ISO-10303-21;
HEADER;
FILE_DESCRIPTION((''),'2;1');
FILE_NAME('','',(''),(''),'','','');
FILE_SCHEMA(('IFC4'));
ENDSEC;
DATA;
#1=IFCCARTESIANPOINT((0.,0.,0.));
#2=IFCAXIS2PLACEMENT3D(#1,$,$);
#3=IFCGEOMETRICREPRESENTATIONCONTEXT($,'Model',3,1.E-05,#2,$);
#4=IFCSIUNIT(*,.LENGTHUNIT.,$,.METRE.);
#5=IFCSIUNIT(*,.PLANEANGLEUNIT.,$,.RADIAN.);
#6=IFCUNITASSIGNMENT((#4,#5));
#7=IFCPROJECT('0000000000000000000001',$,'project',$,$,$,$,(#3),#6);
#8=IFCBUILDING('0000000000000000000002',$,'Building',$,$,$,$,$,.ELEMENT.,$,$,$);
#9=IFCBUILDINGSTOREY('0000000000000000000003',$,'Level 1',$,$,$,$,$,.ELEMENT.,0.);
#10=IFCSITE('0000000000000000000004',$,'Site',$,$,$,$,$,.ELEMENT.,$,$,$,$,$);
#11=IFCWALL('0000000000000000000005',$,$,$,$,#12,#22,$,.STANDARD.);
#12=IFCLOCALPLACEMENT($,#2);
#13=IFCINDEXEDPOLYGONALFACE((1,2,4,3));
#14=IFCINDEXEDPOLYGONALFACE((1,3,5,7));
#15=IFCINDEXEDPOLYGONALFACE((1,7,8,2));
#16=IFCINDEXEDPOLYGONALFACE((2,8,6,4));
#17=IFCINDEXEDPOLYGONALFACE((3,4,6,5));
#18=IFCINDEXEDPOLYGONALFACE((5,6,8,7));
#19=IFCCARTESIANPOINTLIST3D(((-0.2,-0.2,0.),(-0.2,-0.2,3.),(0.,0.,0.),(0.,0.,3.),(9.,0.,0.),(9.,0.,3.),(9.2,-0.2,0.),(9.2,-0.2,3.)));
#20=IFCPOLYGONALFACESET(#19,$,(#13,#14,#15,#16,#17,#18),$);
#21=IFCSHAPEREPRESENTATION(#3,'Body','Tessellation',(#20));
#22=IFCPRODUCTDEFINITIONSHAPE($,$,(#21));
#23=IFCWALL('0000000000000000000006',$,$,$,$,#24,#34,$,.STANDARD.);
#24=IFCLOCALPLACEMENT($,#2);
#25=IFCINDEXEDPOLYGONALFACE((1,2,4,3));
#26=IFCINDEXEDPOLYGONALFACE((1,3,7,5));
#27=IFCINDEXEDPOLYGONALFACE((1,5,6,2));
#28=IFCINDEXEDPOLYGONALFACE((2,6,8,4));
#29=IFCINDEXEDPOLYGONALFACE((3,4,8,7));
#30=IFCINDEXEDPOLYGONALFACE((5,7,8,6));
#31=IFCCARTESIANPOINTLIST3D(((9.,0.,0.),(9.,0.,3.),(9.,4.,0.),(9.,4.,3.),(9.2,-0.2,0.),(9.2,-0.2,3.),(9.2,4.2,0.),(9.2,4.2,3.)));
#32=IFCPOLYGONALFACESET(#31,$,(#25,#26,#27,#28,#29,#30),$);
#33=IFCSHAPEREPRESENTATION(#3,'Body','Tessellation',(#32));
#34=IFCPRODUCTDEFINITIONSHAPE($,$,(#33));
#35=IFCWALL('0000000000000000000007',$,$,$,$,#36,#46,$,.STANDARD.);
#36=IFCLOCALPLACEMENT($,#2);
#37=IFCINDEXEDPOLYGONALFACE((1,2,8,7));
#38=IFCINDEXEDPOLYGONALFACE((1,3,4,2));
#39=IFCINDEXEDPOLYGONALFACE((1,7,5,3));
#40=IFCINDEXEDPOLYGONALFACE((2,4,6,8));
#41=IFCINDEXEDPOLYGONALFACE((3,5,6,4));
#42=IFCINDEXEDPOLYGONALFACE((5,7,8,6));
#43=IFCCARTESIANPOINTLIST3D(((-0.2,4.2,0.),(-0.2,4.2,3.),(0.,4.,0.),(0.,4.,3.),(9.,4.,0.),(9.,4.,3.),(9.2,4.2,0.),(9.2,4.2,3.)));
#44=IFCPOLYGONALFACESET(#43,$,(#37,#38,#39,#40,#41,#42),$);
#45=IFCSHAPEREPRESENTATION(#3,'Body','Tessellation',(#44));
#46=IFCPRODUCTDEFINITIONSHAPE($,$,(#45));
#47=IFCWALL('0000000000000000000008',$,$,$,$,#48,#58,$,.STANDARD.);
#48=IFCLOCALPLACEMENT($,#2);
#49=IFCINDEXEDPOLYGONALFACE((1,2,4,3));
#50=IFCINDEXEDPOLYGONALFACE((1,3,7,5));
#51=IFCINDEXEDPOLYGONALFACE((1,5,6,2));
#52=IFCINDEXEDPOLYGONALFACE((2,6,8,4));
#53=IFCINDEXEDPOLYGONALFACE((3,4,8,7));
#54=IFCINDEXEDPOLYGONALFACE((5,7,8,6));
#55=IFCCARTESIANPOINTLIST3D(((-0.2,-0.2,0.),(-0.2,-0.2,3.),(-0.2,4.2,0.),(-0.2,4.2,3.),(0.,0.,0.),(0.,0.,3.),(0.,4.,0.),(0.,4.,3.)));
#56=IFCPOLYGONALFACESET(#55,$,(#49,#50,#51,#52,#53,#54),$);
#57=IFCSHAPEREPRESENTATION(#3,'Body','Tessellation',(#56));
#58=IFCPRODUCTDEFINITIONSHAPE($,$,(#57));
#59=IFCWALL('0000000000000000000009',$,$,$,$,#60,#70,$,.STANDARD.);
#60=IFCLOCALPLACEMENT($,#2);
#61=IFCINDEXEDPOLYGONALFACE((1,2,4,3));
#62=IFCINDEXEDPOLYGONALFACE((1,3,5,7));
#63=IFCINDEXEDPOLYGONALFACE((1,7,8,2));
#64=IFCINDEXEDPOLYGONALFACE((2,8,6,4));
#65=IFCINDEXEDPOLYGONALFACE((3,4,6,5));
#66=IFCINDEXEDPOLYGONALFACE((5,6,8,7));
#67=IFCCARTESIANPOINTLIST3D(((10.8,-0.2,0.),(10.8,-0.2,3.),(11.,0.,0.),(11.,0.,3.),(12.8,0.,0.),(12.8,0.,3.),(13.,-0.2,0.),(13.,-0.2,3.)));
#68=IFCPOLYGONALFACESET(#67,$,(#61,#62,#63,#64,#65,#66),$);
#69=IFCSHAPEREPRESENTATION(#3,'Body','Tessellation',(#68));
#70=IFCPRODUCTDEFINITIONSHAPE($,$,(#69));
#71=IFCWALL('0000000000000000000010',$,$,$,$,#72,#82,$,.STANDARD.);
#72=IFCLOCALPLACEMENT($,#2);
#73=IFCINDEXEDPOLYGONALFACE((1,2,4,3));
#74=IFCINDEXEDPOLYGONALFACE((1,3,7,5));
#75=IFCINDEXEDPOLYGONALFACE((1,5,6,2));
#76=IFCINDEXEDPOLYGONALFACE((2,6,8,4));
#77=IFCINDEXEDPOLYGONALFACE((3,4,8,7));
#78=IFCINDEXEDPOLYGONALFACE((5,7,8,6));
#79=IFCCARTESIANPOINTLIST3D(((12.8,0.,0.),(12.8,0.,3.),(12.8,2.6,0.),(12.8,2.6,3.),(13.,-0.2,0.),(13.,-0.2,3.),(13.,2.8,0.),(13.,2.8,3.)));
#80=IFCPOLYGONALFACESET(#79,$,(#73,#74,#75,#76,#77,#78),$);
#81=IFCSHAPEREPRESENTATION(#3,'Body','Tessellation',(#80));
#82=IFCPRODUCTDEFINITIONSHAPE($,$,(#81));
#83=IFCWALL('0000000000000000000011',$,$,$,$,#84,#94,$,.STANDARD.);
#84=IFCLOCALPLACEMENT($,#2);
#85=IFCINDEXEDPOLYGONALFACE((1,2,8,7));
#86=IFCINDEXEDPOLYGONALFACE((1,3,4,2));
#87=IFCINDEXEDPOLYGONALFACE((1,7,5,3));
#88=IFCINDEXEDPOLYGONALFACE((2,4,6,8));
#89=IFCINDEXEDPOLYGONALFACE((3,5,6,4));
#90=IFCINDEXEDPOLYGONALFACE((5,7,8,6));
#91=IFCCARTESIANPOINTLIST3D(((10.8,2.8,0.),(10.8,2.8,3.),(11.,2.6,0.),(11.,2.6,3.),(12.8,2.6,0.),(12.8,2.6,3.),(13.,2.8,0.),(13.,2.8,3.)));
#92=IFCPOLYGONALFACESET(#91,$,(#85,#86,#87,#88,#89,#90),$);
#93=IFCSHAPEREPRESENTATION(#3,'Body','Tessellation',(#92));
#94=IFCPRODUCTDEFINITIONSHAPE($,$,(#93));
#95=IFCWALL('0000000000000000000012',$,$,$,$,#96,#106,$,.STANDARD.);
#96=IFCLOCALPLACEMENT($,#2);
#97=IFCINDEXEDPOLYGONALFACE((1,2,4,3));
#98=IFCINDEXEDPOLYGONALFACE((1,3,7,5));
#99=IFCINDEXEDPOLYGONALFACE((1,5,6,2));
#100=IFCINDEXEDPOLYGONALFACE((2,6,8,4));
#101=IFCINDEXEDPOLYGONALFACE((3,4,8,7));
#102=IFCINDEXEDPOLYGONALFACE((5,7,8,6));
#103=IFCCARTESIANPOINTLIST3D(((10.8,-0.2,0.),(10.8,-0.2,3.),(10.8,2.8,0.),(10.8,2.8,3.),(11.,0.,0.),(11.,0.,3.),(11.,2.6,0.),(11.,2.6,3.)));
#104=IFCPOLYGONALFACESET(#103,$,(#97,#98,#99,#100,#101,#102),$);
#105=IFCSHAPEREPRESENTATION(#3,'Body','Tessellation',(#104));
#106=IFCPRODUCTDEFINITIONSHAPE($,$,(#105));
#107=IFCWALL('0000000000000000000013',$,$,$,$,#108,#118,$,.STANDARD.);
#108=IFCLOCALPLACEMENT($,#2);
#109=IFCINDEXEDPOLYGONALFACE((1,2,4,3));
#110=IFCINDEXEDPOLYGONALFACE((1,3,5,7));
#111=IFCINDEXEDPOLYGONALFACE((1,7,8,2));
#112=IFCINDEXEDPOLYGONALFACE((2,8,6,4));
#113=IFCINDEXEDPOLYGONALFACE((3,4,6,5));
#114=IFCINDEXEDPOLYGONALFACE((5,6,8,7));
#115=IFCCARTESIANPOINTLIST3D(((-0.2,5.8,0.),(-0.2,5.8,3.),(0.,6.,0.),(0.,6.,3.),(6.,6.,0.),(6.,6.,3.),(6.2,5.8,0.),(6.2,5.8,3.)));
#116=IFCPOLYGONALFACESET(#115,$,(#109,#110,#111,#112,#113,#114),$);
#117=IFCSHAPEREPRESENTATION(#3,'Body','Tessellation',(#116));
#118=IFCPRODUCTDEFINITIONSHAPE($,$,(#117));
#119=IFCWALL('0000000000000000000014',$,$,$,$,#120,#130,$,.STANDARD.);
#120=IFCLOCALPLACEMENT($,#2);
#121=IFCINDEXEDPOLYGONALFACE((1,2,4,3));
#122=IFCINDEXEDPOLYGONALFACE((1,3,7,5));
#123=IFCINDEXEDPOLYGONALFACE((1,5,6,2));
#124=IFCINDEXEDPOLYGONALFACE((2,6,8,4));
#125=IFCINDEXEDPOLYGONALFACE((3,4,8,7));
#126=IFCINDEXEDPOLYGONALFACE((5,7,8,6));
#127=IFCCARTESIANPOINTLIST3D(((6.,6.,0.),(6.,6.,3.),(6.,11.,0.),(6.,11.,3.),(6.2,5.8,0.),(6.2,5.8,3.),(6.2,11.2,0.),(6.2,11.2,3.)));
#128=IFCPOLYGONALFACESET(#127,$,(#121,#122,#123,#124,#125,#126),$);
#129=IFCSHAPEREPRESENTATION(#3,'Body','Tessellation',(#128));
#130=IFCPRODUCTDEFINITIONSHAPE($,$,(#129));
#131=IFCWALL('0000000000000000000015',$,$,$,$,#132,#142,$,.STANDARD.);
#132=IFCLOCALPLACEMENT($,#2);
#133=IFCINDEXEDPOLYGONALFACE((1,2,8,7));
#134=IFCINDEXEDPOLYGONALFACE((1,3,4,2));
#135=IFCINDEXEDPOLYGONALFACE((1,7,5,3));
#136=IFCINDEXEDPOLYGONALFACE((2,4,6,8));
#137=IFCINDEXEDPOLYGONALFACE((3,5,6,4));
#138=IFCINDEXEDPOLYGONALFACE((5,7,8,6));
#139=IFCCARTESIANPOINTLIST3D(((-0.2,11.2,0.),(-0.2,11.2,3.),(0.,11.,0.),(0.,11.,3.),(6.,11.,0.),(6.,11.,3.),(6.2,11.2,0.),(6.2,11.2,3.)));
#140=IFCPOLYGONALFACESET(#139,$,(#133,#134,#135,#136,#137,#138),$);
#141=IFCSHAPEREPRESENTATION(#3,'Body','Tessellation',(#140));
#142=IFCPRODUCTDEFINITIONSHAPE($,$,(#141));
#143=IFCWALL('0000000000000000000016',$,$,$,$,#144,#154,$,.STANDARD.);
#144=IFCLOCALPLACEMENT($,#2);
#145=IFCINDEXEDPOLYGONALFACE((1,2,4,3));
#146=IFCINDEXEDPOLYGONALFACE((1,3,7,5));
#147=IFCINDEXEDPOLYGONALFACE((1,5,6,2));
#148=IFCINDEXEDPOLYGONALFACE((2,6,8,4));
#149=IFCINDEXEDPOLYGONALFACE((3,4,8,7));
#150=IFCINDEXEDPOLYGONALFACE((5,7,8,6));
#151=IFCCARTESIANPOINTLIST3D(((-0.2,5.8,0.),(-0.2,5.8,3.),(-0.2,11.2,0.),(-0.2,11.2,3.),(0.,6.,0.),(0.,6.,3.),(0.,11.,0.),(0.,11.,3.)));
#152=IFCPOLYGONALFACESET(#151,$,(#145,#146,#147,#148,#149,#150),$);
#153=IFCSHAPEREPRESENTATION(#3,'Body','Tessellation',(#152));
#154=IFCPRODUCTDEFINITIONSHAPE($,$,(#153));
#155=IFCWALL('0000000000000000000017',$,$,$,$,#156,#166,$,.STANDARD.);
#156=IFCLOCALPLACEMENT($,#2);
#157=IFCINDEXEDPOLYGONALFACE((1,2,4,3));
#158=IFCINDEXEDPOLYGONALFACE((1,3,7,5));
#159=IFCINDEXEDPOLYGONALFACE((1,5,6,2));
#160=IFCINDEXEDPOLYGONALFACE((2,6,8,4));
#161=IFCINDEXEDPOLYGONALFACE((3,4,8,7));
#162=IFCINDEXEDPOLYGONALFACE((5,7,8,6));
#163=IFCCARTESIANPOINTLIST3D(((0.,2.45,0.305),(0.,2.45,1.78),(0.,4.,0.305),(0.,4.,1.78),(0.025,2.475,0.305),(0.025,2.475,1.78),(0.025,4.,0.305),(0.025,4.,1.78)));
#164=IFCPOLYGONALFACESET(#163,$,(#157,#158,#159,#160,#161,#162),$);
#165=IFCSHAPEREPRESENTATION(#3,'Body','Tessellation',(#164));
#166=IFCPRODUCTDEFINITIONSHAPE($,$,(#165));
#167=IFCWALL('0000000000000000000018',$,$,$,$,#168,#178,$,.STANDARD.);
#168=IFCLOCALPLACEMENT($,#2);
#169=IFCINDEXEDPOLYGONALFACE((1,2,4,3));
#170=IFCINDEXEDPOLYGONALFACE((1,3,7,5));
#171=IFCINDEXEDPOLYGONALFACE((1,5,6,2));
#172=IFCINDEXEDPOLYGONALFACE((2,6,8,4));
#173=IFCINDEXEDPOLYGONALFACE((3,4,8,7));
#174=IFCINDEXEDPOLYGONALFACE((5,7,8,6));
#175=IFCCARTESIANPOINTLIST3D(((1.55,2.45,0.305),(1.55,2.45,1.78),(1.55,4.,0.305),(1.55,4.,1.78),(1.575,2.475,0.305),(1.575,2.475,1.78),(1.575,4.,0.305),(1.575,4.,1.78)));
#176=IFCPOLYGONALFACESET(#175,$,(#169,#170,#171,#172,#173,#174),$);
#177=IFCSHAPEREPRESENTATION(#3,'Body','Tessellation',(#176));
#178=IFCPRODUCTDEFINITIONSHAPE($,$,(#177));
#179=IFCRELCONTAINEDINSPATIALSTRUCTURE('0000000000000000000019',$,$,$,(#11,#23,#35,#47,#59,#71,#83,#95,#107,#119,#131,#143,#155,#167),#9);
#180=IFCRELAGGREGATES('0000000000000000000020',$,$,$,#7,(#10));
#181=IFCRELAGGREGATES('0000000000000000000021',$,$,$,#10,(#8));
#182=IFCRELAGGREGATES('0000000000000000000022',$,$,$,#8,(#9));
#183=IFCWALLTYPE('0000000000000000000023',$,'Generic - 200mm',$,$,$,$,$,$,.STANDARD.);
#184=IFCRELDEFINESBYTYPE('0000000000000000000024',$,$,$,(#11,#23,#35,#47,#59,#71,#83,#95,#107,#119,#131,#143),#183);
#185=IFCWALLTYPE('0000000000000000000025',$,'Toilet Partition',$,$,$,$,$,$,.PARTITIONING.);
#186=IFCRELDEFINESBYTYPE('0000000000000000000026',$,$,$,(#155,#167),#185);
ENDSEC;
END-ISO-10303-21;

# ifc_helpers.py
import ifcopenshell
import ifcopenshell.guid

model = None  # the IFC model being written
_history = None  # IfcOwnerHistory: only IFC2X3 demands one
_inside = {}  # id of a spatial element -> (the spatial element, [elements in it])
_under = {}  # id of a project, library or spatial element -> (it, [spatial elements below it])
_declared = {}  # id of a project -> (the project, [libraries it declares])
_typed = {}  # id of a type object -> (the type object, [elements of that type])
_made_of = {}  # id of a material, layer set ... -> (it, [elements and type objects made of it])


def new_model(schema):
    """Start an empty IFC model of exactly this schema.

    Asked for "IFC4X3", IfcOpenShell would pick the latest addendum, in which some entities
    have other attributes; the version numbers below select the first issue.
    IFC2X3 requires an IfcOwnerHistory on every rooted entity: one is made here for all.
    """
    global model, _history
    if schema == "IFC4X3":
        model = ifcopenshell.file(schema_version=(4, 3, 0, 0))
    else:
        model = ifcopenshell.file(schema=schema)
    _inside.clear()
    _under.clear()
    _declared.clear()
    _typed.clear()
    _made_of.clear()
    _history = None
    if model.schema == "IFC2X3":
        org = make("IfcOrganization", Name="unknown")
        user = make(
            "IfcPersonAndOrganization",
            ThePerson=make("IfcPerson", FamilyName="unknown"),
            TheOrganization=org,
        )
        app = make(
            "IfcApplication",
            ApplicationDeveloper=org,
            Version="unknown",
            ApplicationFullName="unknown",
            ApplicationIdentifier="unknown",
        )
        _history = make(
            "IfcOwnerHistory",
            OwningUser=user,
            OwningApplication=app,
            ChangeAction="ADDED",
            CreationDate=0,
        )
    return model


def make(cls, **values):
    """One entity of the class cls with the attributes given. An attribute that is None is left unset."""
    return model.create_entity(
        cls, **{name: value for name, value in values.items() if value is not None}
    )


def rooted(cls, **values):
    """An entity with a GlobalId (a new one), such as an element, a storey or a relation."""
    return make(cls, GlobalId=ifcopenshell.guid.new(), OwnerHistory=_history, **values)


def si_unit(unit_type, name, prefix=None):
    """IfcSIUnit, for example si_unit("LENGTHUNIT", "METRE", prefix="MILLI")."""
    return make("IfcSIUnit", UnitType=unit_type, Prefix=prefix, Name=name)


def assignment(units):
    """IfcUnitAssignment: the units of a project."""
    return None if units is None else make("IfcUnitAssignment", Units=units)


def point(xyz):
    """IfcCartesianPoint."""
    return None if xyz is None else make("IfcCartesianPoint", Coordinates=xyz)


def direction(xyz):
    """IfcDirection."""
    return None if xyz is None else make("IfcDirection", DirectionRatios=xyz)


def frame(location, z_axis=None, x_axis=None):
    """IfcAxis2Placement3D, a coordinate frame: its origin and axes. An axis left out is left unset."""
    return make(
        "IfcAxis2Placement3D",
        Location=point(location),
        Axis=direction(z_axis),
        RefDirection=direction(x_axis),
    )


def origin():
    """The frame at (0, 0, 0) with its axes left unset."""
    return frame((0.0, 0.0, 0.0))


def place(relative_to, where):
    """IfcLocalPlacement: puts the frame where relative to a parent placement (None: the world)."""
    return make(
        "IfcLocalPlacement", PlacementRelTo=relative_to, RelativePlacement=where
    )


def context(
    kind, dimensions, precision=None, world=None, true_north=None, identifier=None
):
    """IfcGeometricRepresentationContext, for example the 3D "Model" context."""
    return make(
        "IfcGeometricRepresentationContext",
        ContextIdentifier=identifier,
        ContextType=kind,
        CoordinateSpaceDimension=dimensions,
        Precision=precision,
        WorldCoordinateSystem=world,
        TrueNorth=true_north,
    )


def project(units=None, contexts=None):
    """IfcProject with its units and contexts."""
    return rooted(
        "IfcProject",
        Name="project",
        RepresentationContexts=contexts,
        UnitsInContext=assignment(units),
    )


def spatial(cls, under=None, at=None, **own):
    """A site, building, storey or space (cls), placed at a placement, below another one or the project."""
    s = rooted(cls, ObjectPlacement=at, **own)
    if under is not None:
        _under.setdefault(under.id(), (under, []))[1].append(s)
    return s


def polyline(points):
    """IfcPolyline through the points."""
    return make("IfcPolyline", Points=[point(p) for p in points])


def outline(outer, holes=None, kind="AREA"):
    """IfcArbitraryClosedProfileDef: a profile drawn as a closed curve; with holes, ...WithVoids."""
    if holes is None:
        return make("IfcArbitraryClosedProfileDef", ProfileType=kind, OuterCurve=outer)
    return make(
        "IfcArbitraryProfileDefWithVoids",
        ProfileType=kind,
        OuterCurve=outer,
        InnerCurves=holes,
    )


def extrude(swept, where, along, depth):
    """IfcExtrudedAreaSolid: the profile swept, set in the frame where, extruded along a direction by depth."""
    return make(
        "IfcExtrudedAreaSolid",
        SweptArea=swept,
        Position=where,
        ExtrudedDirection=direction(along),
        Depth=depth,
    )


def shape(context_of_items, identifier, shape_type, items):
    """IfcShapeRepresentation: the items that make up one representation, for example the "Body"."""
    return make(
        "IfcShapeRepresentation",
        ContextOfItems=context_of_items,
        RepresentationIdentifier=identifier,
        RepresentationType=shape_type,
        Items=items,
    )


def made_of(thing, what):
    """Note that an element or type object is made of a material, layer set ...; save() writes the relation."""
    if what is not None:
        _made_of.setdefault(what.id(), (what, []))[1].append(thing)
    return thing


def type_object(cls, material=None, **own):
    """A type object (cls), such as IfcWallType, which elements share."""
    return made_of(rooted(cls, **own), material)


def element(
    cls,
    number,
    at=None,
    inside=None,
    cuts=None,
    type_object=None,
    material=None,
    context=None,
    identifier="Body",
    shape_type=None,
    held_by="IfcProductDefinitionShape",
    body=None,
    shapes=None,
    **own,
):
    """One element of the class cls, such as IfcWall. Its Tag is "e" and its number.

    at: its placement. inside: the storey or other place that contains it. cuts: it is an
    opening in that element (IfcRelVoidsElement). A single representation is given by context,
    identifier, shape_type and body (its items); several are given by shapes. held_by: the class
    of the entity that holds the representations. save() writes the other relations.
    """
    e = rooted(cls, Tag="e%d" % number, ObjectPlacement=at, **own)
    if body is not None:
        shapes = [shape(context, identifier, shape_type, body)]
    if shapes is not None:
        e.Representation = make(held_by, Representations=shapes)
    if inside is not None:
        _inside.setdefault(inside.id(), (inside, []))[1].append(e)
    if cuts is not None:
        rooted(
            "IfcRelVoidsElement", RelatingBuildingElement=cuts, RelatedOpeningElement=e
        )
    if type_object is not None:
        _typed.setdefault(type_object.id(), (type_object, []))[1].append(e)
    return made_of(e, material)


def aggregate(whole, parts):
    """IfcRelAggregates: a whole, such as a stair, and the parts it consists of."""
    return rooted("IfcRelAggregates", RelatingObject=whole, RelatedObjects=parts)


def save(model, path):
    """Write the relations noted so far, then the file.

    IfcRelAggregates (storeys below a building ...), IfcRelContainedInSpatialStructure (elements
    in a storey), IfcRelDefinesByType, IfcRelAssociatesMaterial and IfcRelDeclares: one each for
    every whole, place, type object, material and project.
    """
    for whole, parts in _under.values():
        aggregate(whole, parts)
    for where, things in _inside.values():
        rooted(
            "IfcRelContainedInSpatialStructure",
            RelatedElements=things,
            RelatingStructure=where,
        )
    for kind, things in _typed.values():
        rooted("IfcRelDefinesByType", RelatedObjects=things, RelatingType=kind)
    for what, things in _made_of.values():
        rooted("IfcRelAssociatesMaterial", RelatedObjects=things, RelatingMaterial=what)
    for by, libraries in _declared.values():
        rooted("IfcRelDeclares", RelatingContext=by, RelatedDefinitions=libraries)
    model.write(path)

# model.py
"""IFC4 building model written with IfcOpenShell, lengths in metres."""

from ifc_helpers import new_model, si_unit, frame, origin, place, context, project, spatial, polyline, outline, extrude, type_object, element, save


model = new_model("IFC4")

# Units and contexts
model_context = context("Model", 3, precision=1e-05, world=origin())
ifc_project = project(units=[si_unit("LENGTHUNIT", "METRE"), si_unit("PLANEANGLEUNIT", "RADIAN")], contexts=[model_context])

# Site, building, storey
site = spatial("IfcSite", under=ifc_project, Name="Site", CompositionType="ELEMENT")
building = spatial("IfcBuilding", under=site, Name="Building", CompositionType="ELEMENT")
storey = spatial("IfcBuildingStorey", under=building, Name="Level 1", CompositionType="ELEMENT", Elevation=0.0)

# Walls
wall_type_1 = type_object("IfcWallType", Name="Generic - 200mm", PredefinedType="STANDARD")
wall_1_placement = place(None, frame((-0.1, -0.1, 0.0), z_axis=(0.0, 0.0, 1.0), x_axis=(1.0, 0.0, 0.0)))
element("IfcWall", 1, at=wall_1_placement, inside=storey, type_object=wall_type_1, PredefinedType="STANDARD", context=model_context, shape_type="SweptSolid", body=[
    extrude(outline(polyline([(-0.1, -0.1), (9.3, -0.1), (9.1, 0.1), (0.1, 0.1), (-0.1, -0.1)])), origin(), (0.0, 0.0, 1.0), 3.0),
])
wall_2_placement = place(None, frame((9.1, -0.1, 0.0), z_axis=(0.0, 0.0, 1.0), x_axis=(0.0, 1.0, 0.0)))
element("IfcWall", 2, at=wall_2_placement, inside=storey, type_object=wall_type_1, PredefinedType="STANDARD", context=model_context, shape_type="SweptSolid", body=[
    extrude(outline(polyline([(-0.1, -0.1), (4.3, -0.1), (4.1, 0.1), (0.1, 0.1), (-0.1, -0.1)])), origin(), (0.0, 0.0, 1.0), 3.0),
])
wall_3_placement = place(None, frame((9.1, 4.1, 0.0), z_axis=(0.0, 0.0, 1.0), x_axis=(-1.0, 0.0, 0.0)))
element("IfcWall", 3, at=wall_3_placement, inside=storey, type_object=wall_type_1, PredefinedType="STANDARD", context=model_context, shape_type="SweptSolid", body=[
    extrude(outline(polyline([(-0.1, -0.1), (9.3, -0.1), (9.1, 0.1), (0.1, 0.1), (-0.1, -0.1)])), origin(), (0.0, 0.0, 1.0), 3.0),
])
wall_4_placement = place(None, frame((-0.1, 4.1, 0.0), z_axis=(0.0, 0.0, 1.0), x_axis=(0.0, -1.0, 0.0)))
element("IfcWall", 4, at=wall_4_placement, inside=storey, type_object=wall_type_1, PredefinedType="STANDARD", context=model_context, shape_type="SweptSolid", body=[
    extrude(outline(polyline([(-0.1, -0.1), (4.3, -0.1), (4.1, 0.1), (0.1, 0.1), (-0.1, -0.1)])), origin(), (0.0, 0.0, 1.0), 3.0),
])
wall_5_placement = place(None, frame((10.9, -0.1, 0.0), z_axis=(0.0, 0.0, 1.0), x_axis=(1.0, 0.0, 0.0)))
element("IfcWall", 5, at=wall_5_placement, inside=storey, type_object=wall_type_1, PredefinedType="STANDARD", context=model_context, shape_type="SweptSolid", body=[
    extrude(outline(polyline([(-0.1, -0.1), (2.1, -0.1), (1.9, 0.1), (0.1, 0.1), (-0.1, -0.1)])), origin(), (0.0, 0.0, 1.0), 3.0),
])
wall_6_placement = place(None, frame((12.9, -0.1, 0.0), z_axis=(0.0, 0.0, 1.0), x_axis=(0.0, 1.0, 0.0)))
element("IfcWall", 6, at=wall_6_placement, inside=storey, type_object=wall_type_1, PredefinedType="STANDARD", context=model_context, shape_type="SweptSolid", body=[
    extrude(outline(polyline([(-0.1, -0.1), (2.9, -0.1), (2.7, 0.1), (0.1, 0.1), (-0.1, -0.1)])), origin(), (0.0, 0.0, 1.0), 3.0),
])
wall_7_placement = place(None, frame((12.9, 2.7, 0.0), z_axis=(0.0, 0.0, 1.0), x_axis=(-1.0, 0.0, 0.0)))
element("IfcWall", 7, at=wall_7_placement, inside=storey, type_object=wall_type_1, PredefinedType="STANDARD", context=model_context, shape_type="SweptSolid", body=[
    extrude(outline(polyline([(-0.1, -0.1), (2.1, -0.1), (1.9, 0.1), (0.1, 0.1), (-0.1, -0.1)])), origin(), (0.0, 0.0, 1.0), 3.0),
])
wall_8_placement = place(None, frame((10.9, 2.7, 0.0), z_axis=(0.0, 0.0, 1.0), x_axis=(0.0, -1.0, 0.0)))
element("IfcWall", 8, at=wall_8_placement, inside=storey, type_object=wall_type_1, PredefinedType="STANDARD", context=model_context, shape_type="SweptSolid", body=[
    extrude(outline(polyline([(-0.1, -0.1), (2.9, -0.1), (2.7, 0.1), (0.1, 0.1), (-0.1, -0.1)])), origin(), (0.0, 0.0, 1.0), 3.0),
])
wall_9_placement = place(None, frame((-0.1, 5.9, 0.0), z_axis=(0.0, 0.0, 1.0), x_axis=(1.0, 0.0, 0.0)))
element("IfcWall", 9, at=wall_9_placement, inside=storey, type_object=wall_type_1, PredefinedType="STANDARD", context=model_context, shape_type="SweptSolid", body=[
    extrude(outline(polyline([(-0.1, -0.1), (6.3, -0.1), (6.1, 0.1), (0.1, 0.1), (-0.1, -0.1)])), origin(), (0.0, 0.0, 1.0), 3.0),
])
wall_10_placement = place(None, frame((6.1, 5.9, 0.0), z_axis=(0.0, 0.0, 1.0), x_axis=(0.0, 1.0, 0.0)))
element("IfcWall", 10, at=wall_10_placement, inside=storey, type_object=wall_type_1, PredefinedType="STANDARD", context=model_context, shape_type="SweptSolid", body=[
    extrude(outline(polyline([(-0.1, -0.1), (5.3, -0.1), (5.1, 0.1), (0.1, 0.1), (-0.1, -0.1)])), origin(), (0.0, 0.0, 1.0), 3.0),
])
wall_11_placement = place(None, frame((6.1, 11.1, 0.0), z_axis=(0.0, 0.0, 1.0), x_axis=(-1.0, 0.0, 0.0)))
element("IfcWall", 11, at=wall_11_placement, inside=storey, type_object=wall_type_1, PredefinedType="STANDARD", context=model_context, shape_type="SweptSolid", body=[
    extrude(outline(polyline([(-0.1, -0.1), (6.3, -0.1), (6.1, 0.1), (0.1, 0.1), (-0.1, -0.1)])), origin(), (0.0, 0.0, 1.0), 3.0),
])
wall_12_placement = place(None, frame((-0.1, 11.1, 0.0), z_axis=(0.0, 0.0, 1.0), x_axis=(0.0, -1.0, 0.0)))
element("IfcWall", 12, at=wall_12_placement, inside=storey, type_object=wall_type_1, PredefinedType="STANDARD", context=model_context, shape_type="SweptSolid", body=[
    extrude(outline(polyline([(-0.1, -0.1), (5.3, -0.1), (5.1, 0.1), (0.1, 0.1), (-0.1, -0.1)])), origin(), (0.0, 0.0, 1.0), 3.0),
])
wall_type_2 = type_object("IfcWallType", Name="Toilet Partition", PredefinedType="PARTITIONING")
wall_13_placement = place(None, frame((0.0125, 4.0, 0.305), z_axis=(0.0, 0.0, 1.0), x_axis=(0.0, -1.0, 0.0)))
element("IfcWall", 13, at=wall_13_placement, inside=storey, type_object=wall_type_2, PredefinedType="STANDARD", context=model_context, shape_type="SweptSolid", body=[
    extrude(outline(polyline([(0.0, -0.0125), (1.55, -0.0125), (1.525, 0.0125), (0.0, 0.0125), (0.0, -0.0125)])), origin(), (0.0, 0.0, 1.0), 1.475),
])
wall_14_placement = place(None, frame((1.5625, 4.0, 0.305), z_axis=(0.0, 0.0, 1.0), x_axis=(0.0, -1.0, 0.0)))
element("IfcWall", 14, at=wall_14_placement, inside=storey, type_object=wall_type_2, PredefinedType="STANDARD", context=model_context, shape_type="SweptSolid", body=[
    extrude(outline(polyline([(0.0, -0.0125), (1.55, -0.0125), (1.525, 0.0125), (0.0, 0.0125), (0.0, -0.0125)])), origin(), (0.0, 0.0, 1.0), 1.475),
])

save(model, "model.ifc")
